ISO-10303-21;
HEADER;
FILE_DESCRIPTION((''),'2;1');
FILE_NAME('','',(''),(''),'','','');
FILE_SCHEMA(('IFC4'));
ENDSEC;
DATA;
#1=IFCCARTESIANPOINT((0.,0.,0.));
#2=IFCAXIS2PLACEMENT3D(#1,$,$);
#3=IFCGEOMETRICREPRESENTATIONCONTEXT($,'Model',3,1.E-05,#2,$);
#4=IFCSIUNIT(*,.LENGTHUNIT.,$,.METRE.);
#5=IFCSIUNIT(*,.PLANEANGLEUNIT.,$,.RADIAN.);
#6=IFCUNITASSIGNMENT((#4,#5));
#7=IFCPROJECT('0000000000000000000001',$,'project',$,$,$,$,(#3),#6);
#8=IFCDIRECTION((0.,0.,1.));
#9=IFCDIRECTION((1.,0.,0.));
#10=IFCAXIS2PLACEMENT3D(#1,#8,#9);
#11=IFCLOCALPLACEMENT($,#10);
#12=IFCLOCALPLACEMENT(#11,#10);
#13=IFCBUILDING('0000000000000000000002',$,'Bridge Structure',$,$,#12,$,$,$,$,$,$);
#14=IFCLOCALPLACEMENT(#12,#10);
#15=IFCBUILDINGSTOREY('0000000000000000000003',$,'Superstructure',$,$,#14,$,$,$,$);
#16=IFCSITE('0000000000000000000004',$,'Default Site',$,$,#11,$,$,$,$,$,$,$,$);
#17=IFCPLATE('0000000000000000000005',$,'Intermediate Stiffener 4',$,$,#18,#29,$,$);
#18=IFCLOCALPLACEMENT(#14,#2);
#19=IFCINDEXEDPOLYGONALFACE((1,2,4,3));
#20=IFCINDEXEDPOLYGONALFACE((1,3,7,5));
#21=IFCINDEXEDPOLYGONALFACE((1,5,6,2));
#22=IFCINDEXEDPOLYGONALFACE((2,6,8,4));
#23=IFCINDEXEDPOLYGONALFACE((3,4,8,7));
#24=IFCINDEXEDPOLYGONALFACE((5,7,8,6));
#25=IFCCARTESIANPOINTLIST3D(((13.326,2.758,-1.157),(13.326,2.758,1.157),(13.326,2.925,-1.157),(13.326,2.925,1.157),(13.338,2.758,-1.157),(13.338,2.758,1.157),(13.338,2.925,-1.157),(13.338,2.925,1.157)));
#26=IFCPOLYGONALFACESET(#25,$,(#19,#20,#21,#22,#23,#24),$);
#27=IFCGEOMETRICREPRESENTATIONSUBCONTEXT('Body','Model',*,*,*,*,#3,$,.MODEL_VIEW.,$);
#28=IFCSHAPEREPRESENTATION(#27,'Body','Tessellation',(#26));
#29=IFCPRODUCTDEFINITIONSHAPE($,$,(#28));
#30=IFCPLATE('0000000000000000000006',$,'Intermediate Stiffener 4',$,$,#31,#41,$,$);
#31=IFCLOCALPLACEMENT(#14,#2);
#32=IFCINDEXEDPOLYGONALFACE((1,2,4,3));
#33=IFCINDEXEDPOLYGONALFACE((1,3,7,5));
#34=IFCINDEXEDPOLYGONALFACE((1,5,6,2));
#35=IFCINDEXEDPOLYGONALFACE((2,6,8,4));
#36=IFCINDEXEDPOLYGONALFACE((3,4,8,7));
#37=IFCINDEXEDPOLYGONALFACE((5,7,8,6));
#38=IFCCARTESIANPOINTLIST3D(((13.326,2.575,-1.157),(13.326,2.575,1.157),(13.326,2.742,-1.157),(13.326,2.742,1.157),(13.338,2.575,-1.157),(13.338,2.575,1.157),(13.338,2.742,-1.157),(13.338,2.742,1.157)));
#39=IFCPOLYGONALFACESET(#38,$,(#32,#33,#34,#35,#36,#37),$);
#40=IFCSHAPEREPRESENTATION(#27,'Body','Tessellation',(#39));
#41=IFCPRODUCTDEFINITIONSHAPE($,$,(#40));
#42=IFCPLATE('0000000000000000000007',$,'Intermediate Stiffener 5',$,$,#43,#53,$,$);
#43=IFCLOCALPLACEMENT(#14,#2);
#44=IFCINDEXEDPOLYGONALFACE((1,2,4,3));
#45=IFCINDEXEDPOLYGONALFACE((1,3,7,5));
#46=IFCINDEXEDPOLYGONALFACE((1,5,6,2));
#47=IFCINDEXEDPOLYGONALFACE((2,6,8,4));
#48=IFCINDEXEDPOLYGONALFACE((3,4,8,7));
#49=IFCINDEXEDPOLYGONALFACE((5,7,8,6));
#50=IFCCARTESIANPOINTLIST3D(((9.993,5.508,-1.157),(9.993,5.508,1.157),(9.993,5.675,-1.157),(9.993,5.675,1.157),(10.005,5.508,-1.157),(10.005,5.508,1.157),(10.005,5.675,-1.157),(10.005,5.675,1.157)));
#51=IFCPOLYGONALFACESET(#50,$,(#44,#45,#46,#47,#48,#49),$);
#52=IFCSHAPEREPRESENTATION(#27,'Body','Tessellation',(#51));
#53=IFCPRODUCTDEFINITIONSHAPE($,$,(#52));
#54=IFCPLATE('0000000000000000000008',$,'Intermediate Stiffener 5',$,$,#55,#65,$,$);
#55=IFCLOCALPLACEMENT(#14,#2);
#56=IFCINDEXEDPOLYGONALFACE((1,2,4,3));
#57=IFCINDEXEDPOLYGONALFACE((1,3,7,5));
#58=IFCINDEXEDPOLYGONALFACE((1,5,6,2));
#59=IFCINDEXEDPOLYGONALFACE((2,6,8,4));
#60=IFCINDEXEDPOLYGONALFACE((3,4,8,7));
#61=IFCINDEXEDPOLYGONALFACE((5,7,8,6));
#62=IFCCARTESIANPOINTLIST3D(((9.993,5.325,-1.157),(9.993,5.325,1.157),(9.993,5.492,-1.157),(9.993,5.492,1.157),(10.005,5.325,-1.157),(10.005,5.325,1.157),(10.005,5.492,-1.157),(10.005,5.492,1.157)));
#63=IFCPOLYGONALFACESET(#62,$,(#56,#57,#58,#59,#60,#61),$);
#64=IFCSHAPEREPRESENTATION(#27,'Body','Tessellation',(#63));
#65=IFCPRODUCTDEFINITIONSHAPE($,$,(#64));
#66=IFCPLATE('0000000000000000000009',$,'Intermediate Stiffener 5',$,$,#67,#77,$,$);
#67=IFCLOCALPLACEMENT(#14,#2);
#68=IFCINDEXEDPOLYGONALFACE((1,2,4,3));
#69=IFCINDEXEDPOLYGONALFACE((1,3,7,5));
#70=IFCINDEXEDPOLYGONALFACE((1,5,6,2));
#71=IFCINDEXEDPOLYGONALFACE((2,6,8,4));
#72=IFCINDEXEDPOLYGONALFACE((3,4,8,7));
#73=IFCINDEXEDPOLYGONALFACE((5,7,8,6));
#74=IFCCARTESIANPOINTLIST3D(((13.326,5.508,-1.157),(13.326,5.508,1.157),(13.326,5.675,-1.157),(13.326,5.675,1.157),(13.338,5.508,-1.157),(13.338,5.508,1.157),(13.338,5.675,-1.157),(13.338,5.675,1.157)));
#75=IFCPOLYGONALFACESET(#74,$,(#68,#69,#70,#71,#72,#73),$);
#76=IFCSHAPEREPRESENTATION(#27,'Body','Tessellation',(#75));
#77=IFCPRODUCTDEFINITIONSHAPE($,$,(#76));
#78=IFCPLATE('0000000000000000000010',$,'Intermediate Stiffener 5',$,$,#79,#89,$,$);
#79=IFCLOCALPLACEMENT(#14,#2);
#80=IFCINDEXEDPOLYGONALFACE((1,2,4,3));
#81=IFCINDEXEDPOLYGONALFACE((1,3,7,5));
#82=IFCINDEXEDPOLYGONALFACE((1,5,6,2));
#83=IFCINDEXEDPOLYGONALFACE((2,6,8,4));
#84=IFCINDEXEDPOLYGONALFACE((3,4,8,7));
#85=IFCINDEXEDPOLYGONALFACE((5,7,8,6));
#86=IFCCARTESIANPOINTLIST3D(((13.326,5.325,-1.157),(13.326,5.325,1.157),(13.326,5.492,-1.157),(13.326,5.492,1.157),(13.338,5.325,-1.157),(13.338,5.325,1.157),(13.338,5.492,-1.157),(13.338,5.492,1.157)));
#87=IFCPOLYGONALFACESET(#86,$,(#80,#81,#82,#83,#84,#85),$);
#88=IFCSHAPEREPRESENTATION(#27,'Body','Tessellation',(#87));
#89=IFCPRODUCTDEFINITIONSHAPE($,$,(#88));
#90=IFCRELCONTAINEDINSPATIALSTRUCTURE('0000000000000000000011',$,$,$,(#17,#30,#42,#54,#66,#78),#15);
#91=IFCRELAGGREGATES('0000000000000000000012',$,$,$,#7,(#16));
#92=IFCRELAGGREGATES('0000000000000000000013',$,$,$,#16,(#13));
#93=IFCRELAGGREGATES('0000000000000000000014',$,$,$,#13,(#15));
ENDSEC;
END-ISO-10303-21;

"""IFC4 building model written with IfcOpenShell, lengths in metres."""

from ifc_helpers import new_model, si_unit, frame, origin, origin_with_axes, origin_2d_with_axis, place, context, subcontext, project, spatial, rectangle, extrude, element, save


model = new_model("IFC4")

# Units and contexts
model_context = context("Model", 3, precision=1e-05, world=origin())
body_context = subcontext(model_context, "Body", "Model", "MODEL_VIEW")
ifc_project = project(units=[si_unit("LENGTHUNIT", "METRE"), si_unit("PLANEANGLEUNIT", "RADIAN")], contexts=[model_context])

# Site, building, storey
site_placement = place(None, origin_with_axes())
site = spatial("IfcSite", under=ifc_project, at=site_placement, Name="Default Site")
building_placement = place(site_placement, origin_with_axes())
building = spatial("IfcBuilding", under=site, at=building_placement, Name="Bridge Structure")
storey_placement = place(building_placement, origin_with_axes())
storey = spatial("IfcBuildingStorey", under=building, at=storey_placement, Name="Superstructure")

# Plates
for number, where, z_axis, x_axis, name in (
    (1, (13.332, 2.8415, -1.157), (0.0, 0.0, 1.0), (1.0, 0.0, 0.0), "Intermediate Stiffener 4"),
    (2, (13.332, 2.6585, -1.157), (0.0, 0.0, 1.0), (1.0, 0.0, 0.0), "Intermediate Stiffener 4"),
    (3, (9.999, 5.5915, -1.157), (0.0, 0.0, 1.0), (1.0, 0.0, 0.0), "Intermediate Stiffener 5"),
    (4, (9.999, 5.4085, -1.157), (0.0, 0.0, 1.0), (1.0, 0.0, 0.0), "Intermediate Stiffener 5"),
    (5, (13.332, 5.5915, -1.157), (0.0, 0.0, 1.0), (1.0, 0.0, 0.0), "Intermediate Stiffener 5"),
    (6, (13.332, 5.4085, -1.157), (0.0, 0.0, 1.0), (1.0, 0.0, 0.0), "Intermediate Stiffener 5"),
):
    element("IfcPlate", number, at=place(storey_placement, frame(where, z_axis=z_axis, x_axis=x_axis)), inside=storey, Name=name, context=body_context, shape_type="SweptSolid", body=[
        extrude(rectangle(XDim=0.012, YDim=0.167, at=origin_2d_with_axis()), origin_with_axes(), (0.0, 0.0, 1.0), 2.314),
    ])

save(model, "model.ifc")
